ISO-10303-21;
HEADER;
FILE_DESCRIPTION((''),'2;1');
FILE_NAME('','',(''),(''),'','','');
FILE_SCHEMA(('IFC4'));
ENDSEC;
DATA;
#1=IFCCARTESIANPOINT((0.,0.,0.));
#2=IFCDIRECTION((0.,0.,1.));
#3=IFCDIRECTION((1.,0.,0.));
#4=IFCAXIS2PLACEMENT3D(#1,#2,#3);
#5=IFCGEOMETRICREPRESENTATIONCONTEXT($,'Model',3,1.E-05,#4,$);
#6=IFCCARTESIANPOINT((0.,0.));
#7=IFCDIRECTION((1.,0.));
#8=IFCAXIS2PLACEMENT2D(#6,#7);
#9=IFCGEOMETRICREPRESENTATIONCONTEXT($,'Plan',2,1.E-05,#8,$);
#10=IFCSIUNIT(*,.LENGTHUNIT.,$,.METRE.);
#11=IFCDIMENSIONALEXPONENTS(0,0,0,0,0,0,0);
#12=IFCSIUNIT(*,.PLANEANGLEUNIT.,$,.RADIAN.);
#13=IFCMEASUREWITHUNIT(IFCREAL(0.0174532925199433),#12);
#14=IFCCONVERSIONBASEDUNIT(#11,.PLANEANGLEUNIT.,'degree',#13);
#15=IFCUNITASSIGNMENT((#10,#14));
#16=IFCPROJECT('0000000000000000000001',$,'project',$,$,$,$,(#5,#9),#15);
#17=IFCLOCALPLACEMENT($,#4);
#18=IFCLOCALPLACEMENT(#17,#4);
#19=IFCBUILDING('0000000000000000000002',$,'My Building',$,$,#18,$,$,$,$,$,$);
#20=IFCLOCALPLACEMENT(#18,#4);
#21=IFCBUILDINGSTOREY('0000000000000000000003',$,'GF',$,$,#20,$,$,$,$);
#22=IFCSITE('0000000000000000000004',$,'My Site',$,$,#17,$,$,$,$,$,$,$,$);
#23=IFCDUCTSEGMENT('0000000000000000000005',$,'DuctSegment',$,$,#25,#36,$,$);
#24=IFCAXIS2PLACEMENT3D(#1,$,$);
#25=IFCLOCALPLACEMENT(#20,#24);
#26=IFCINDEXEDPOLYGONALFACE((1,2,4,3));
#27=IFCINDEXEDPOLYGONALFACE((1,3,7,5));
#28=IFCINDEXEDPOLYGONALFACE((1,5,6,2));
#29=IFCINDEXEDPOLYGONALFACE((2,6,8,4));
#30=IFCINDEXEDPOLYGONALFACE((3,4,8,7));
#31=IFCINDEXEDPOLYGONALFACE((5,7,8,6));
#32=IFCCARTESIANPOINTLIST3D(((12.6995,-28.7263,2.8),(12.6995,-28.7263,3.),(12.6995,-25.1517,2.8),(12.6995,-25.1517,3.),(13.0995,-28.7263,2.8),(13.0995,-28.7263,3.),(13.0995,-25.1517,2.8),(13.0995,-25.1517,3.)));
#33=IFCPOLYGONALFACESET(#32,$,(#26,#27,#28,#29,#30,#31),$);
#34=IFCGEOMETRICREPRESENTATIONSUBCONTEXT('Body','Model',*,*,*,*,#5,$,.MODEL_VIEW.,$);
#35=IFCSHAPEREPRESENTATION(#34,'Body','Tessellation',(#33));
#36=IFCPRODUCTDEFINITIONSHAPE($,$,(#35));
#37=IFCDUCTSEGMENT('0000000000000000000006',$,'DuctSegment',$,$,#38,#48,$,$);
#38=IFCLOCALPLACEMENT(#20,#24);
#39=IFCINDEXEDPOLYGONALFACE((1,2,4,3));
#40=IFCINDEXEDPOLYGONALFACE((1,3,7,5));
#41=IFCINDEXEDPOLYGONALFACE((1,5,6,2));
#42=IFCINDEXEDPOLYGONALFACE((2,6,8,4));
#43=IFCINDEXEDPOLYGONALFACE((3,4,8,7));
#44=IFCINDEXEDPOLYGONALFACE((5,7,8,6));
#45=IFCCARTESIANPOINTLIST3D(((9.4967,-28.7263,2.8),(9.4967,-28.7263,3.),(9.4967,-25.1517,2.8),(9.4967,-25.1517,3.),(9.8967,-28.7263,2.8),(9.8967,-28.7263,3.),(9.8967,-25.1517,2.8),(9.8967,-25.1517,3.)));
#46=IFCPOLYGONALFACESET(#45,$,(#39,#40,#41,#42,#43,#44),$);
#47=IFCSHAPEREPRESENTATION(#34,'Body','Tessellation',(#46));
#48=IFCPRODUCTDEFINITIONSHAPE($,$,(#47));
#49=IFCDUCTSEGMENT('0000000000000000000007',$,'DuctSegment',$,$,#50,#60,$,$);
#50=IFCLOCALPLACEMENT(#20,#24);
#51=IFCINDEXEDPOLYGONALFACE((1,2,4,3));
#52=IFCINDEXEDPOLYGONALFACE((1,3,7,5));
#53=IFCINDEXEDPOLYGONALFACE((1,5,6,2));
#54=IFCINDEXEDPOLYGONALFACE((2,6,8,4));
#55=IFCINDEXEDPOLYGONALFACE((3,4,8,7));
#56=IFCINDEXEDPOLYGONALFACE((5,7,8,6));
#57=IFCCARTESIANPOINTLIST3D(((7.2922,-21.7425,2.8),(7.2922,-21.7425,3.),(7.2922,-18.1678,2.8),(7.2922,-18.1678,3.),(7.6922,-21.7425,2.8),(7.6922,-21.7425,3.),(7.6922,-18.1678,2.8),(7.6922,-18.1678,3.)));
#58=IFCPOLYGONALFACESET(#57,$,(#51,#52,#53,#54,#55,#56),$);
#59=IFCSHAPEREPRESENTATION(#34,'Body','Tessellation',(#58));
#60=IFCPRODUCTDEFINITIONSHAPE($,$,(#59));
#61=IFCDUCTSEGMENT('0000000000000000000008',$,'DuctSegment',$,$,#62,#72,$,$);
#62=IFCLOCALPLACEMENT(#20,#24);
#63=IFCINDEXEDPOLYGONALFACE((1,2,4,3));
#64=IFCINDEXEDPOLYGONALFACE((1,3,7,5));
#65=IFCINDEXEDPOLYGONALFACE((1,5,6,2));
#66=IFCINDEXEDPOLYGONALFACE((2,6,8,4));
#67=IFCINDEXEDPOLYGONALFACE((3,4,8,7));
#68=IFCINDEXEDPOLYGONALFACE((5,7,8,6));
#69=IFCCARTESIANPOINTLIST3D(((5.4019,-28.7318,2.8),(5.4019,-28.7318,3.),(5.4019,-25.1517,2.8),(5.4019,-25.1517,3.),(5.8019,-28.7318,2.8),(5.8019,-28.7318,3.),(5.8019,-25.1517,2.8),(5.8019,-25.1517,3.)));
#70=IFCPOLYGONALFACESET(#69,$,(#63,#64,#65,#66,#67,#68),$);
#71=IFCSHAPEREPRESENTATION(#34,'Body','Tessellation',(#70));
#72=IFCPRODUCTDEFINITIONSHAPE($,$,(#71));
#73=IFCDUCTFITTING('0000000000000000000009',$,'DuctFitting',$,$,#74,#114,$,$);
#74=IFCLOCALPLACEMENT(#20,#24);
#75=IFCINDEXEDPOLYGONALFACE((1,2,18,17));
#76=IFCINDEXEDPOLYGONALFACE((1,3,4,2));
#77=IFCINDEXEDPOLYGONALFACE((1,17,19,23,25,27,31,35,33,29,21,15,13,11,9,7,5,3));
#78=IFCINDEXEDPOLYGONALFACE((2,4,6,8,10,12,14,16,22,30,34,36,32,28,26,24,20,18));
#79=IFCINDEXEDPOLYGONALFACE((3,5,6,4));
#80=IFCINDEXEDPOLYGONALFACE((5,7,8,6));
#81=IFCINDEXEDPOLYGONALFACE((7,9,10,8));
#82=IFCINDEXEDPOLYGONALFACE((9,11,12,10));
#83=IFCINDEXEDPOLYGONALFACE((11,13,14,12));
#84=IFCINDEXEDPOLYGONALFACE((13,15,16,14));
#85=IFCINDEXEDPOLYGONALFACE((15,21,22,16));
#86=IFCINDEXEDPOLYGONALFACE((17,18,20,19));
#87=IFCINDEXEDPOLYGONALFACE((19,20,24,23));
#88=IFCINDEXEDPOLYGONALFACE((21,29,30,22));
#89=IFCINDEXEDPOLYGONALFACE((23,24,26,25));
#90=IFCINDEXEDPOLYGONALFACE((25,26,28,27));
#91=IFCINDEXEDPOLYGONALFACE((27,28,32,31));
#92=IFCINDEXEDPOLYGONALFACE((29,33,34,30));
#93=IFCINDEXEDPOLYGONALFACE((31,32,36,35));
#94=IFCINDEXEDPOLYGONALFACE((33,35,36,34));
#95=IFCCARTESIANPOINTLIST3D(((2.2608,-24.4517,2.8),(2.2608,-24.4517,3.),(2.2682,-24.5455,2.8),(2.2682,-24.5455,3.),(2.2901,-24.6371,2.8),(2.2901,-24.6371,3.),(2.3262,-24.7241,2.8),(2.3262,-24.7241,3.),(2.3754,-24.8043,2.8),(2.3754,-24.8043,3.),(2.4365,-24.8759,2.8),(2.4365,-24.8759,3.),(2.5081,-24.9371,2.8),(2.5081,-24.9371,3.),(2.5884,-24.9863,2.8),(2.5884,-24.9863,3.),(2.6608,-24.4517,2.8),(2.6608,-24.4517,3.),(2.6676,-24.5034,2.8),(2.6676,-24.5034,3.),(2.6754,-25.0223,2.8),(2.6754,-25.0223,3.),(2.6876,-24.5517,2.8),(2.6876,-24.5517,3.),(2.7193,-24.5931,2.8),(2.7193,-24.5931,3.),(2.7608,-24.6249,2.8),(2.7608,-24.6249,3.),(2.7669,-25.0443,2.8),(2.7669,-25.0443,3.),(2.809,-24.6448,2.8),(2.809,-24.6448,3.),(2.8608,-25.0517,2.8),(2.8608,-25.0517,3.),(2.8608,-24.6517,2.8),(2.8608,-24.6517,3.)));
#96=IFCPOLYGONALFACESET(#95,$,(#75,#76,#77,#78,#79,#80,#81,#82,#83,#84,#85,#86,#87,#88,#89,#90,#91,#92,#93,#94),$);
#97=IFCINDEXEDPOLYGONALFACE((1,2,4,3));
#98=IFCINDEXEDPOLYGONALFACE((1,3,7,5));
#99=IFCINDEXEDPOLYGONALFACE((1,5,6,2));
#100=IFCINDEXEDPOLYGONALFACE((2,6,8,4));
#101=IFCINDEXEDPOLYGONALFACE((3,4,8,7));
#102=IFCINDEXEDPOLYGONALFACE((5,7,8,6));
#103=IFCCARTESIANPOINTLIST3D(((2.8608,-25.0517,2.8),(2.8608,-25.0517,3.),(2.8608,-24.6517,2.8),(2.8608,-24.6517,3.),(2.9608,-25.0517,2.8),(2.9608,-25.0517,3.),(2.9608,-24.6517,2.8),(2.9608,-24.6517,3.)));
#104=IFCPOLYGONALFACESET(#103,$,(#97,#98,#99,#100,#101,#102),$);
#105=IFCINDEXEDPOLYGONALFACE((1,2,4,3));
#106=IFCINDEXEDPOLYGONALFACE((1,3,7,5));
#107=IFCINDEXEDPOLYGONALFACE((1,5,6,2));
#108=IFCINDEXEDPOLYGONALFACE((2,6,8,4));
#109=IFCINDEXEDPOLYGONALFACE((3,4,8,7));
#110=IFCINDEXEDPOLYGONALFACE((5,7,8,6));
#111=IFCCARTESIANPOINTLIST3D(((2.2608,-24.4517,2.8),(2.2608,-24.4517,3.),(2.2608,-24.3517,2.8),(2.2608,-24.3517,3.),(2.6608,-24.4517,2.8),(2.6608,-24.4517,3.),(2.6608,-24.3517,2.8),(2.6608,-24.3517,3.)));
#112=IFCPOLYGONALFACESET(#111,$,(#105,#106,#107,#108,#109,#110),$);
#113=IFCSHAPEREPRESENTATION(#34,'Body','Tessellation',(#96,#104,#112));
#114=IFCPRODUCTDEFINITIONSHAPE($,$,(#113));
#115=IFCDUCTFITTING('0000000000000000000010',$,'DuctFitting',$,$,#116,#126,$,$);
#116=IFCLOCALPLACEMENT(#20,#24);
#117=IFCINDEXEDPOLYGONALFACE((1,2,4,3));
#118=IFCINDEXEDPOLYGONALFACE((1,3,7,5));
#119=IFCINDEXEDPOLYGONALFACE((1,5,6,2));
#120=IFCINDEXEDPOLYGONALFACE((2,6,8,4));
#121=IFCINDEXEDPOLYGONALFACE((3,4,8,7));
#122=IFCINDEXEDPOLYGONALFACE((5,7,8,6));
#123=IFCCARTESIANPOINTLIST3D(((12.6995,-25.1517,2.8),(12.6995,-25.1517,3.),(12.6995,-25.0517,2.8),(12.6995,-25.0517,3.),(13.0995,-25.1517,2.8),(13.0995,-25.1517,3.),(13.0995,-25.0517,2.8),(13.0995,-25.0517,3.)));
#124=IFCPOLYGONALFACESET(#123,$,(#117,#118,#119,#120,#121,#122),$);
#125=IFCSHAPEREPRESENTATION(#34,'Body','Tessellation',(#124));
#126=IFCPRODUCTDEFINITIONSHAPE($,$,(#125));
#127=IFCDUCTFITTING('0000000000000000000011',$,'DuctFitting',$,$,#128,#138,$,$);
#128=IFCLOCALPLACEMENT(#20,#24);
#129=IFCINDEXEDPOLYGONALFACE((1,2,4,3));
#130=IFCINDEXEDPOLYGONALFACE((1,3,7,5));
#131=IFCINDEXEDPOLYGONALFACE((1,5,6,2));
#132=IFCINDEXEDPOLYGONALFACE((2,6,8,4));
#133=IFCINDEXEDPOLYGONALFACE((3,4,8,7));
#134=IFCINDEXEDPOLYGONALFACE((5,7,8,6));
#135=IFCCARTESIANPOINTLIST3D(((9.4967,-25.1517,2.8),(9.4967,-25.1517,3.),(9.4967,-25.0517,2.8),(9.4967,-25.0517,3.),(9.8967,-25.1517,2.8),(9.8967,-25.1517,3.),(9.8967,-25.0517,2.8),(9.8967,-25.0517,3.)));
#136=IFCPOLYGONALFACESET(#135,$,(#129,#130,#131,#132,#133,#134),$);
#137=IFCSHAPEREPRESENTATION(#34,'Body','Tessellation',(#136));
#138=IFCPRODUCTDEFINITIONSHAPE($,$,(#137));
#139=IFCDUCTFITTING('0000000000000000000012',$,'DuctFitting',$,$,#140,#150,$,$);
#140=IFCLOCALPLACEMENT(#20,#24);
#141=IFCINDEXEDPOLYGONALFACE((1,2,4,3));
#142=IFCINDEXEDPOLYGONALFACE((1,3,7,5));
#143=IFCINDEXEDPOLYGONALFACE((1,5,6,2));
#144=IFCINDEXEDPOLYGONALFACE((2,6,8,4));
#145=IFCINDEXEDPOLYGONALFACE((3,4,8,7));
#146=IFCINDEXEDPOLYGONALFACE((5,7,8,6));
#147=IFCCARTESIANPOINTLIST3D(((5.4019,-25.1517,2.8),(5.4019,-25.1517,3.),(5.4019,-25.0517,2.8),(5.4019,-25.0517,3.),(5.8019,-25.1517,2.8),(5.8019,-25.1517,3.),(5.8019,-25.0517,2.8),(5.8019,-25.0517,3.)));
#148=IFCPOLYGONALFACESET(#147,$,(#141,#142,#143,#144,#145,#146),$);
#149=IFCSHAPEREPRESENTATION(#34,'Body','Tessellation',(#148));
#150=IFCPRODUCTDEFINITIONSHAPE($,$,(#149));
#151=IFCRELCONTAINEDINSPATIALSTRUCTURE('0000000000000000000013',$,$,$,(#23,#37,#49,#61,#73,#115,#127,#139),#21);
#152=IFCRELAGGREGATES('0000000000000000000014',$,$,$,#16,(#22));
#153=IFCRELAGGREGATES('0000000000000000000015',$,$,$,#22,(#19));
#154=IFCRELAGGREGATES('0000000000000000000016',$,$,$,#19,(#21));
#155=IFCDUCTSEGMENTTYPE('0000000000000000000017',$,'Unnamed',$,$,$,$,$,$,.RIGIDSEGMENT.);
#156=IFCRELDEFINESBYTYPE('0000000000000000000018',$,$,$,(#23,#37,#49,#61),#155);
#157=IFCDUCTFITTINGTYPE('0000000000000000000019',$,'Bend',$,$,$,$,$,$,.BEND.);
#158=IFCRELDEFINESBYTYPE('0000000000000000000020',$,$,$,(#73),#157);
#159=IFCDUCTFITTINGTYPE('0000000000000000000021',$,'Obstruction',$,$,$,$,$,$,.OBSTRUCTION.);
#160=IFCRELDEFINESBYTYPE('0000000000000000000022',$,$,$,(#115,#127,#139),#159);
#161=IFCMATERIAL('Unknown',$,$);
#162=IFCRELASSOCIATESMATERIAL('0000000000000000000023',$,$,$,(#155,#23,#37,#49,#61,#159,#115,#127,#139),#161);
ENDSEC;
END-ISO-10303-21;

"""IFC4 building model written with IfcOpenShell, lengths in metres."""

from ifc_helpers import new_model, entity, si_unit, converted_unit, frame, origin_with_axes, origin_2d_with_axis, place, context, subcontext, project, spatial, line, arc, indexed_curve, rectangle, outline, extrude, source, transform, mapped, material, material_profile, profile_set, profile_usage, type_object, type_shapes, element, save


model = new_model("IFC4")

# Units and contexts
model_context = context("Model", 3, precision=1e-05, world=origin_with_axes())
plan_context = context("Plan", 2, precision=1e-05, world=origin_2d_with_axis())
body_context_1 = subcontext(model_context, "Body", "Model", "MODEL_VIEW")
ifc_project = project(units=[si_unit("LENGTHUNIT", "METRE"), converted_unit("PLANEANGLEUNIT", "degree", entity("IfcReal", 0.0174532925199433), si_unit("PLANEANGLEUNIT", "RADIAN"), dimensions=[0, 0, 0, 0, 0, 0, 0])], contexts=[model_context, plan_context])

# Site, building, storey
site_placement = place(None, origin_with_axes())
site = spatial("IfcSite", under=ifc_project, at=site_placement, Name="My Site")
building_placement = place(site_placement, origin_with_axes())
building = spatial("IfcBuilding", under=site, at=building_placement, Name="My Building")
storey_placement = place(building_placement, origin_with_axes())
storey = spatial("IfcBuildingStorey", under=building, at=storey_placement, Name="GF")

# Shared definitions
ifc_material = material(Name="Unknown")

# Duct segments
ifc_material_profile_1 = material_profile(ifc_material, rectangle(XDim=0.4, YDim=0.2))
ifc_profile_set_1 = profile_set([ifc_material_profile_1])
duct_segment_type = type_object("IfcDuctSegmentType", Name="Unnamed", PredefinedType="RIGIDSEGMENT", material=ifc_profile_set_1)
ifc_profile_usage_1 = profile_usage(ifc_profile_set_1, cardinal=5)
duct_segment_1_placement = place(storey_placement, frame((12.8995, -25.1517, 2.9), z_axis=(0.0, -1.0, 0.0), x_axis=(1.0, 0.0, 0.0)))
element("IfcDuctSegment", 1, at=duct_segment_1_placement, inside=storey, type_object=duct_segment_type, material=ifc_profile_usage_1, Name="DuctSegment", context=body_context_1, shape_type="SweptSolid", body=[
    extrude(rectangle(XDim=0.4, YDim=0.2), origin_with_axes(), (0.0, 0.0, 1.0), 3.5747),
])
ifc_profile_usage_2 = profile_usage(ifc_profile_set_1, cardinal=5)
duct_segment_2_placement = place(storey_placement, frame((9.6967, -25.1517, 2.9), z_axis=(0.0, -1.0, 0.0), x_axis=(1.0, 0.0, 0.0)))
element("IfcDuctSegment", 2, at=duct_segment_2_placement, inside=storey, type_object=duct_segment_type, material=ifc_profile_usage_2, Name="DuctSegment", context=body_context_1, shape_type="SweptSolid", body=[
    extrude(rectangle(XDim=0.4, YDim=0.2), origin_with_axes(), (0.0, 0.0, 1.0), 3.5747),
])
ifc_profile_usage_3 = profile_usage(ifc_profile_set_1, cardinal=5)
duct_segment_3_placement = place(storey_placement, frame((7.4922, -18.1678, 2.9), z_axis=(0.0, -1.0, 0.0), x_axis=(1.0, 0.0, 0.0)))
element("IfcDuctSegment", 3, at=duct_segment_3_placement, inside=storey, type_object=duct_segment_type, material=ifc_profile_usage_3, Name="DuctSegment", context=body_context_1, shape_type="SweptSolid", body=[
    extrude(rectangle(XDim=0.4, YDim=0.2), origin_with_axes(), (0.0, 0.0, 1.0), 3.5747),
])
ifc_profile_usage_4 = profile_usage(ifc_profile_set_1, cardinal=5)
duct_segment_4_placement = place(storey_placement, frame((5.6019, -25.1517, 2.9), z_axis=(0.0, -1.0, 0.0), x_axis=(1.0, 0.0, 0.0)))
element("IfcDuctSegment", 4, at=duct_segment_4_placement, inside=storey, type_object=duct_segment_type, material=ifc_profile_usage_4, Name="DuctSegment", context=body_context_1, shape_type="SweptSolid", body=[
    extrude(rectangle(XDim=0.4, YDim=0.2), origin_with_axes(), (0.0, 0.0, 1.0), 3.5801),
])

# Duct fittings
duct_fitting_type_1 = type_object("IfcDuctFittingType", Name="Bend", PredefinedType="BEND")
shared_shape_1 = source(origin_with_axes(), body_context_1, "Body", "SweptSolid", [
    extrude(outline(indexed_curve([(0.2, 0.0), (0.2586, 0.1414), (0.4, 0.2), (0.4, 0.6), (-0.0243, 0.4243), (-0.2, 0.0)], segments=[arc(1, 2, 3), line(3, 4), arc(4, 5, 6), line(6, 1)])), frame((0.0, -0.1, 0.1), z_axis=(0.0, -1.0, 0.0), x_axis=(1.0, 0.0, 0.0)), (0.0, 0.0, -1.0), 0.2),
    extrude(rectangle(XDim=0.4, YDim=0.2), origin_with_axes(), (0.0, 0.0, 1.0), 0.1),
    extrude(rectangle(XDim=0.4, YDim=0.2), frame((0.4, 0.0, 0.5), z_axis=(1.0, 0.0, 0.0), x_axis=(0.0, 0.0, 1.0)), (0.0, 0.0, 1.0), 0.1),
])
type_shapes(duct_fitting_type_1, [shared_shape_1])
duct_fitting_1_placement = place(storey_placement, frame((2.9608, -24.8517, 2.9), z_axis=(-1.0, 0.0, 0.0), x_axis=(0.0, 1.0, 0.0)))
element("IfcDuctFitting", 5, at=duct_fitting_1_placement, inside=storey, type_object=duct_fitting_type_1, Name="DuctFitting", context=body_context_1, shape_type="MappedRepresentation", body=[
    mapped(shared_shape_1, transform((0.0, 0.0, 0.0), x_axis=(1.0, 0.0, 0.0), y_axis=(0.0, 1.0, 0.0), z_axis=(0.0, 0.0, 1.0), scale=1.0)),
])
ifc_material_profile_2 = material_profile(ifc_material, rectangle(XDim=0.4, YDim=0.2))
ifc_profile_set_2 = profile_set([ifc_material_profile_2])
ifc_profile_usage_5 = profile_usage(ifc_profile_set_2, cardinal=5)
duct_fitting_type_2 = type_object("IfcDuctFittingType", Name="Obstruction", PredefinedType="OBSTRUCTION", material=ifc_profile_set_2)
duct_fitting_2_placement = place(storey_placement, frame((12.8995, -25.0517, 2.9), z_axis=(0.0, -1.0, 0.0), x_axis=(1.0, 0.0, 0.0)))
element("IfcDuctFitting", 6, at=duct_fitting_2_placement, inside=storey, type_object=duct_fitting_type_2, material=ifc_profile_usage_5, Name="DuctFitting", context=body_context_1, shape_type="SweptSolid", body=[
    extrude(rectangle(XDim=0.4, YDim=0.2), origin_with_axes(), (0.0, 0.0, 1.0), 0.1),
])
ifc_profile_usage_6 = profile_usage(ifc_profile_set_2, cardinal=5)
duct_fitting_3_placement = place(storey_placement, frame((9.6967, -25.0517, 2.9), z_axis=(0.0, -1.0, 0.0), x_axis=(1.0, 0.0, 0.0)))
element("IfcDuctFitting", 7, at=duct_fitting_3_placement, inside=storey, type_object=duct_fitting_type_2, material=ifc_profile_usage_6, Name="DuctFitting", context=body_context_1, shape_type="SweptSolid", body=[
    extrude(rectangle(XDim=0.4, YDim=0.2), origin_with_axes(), (0.0, 0.0, 1.0), 0.1),
])
ifc_profile_usage_7 = profile_usage(ifc_profile_set_2, cardinal=5)
duct_fitting_4_placement = place(storey_placement, frame((5.6019, -25.0517, 2.9), z_axis=(0.0, -1.0, 0.0), x_axis=(1.0, 0.0, 0.0)))
element("IfcDuctFitting", 8, at=duct_fitting_4_placement, inside=storey, type_object=duct_fitting_type_2, material=ifc_profile_usage_7, Name="DuctFitting", context=body_context_1, shape_type="SweptSolid", body=[
    extrude(rectangle(XDim=0.4, YDim=0.2), origin_with_axes(), (0.0, 0.0, 1.0), 0.1),
])

save(model, "model.ifc")
